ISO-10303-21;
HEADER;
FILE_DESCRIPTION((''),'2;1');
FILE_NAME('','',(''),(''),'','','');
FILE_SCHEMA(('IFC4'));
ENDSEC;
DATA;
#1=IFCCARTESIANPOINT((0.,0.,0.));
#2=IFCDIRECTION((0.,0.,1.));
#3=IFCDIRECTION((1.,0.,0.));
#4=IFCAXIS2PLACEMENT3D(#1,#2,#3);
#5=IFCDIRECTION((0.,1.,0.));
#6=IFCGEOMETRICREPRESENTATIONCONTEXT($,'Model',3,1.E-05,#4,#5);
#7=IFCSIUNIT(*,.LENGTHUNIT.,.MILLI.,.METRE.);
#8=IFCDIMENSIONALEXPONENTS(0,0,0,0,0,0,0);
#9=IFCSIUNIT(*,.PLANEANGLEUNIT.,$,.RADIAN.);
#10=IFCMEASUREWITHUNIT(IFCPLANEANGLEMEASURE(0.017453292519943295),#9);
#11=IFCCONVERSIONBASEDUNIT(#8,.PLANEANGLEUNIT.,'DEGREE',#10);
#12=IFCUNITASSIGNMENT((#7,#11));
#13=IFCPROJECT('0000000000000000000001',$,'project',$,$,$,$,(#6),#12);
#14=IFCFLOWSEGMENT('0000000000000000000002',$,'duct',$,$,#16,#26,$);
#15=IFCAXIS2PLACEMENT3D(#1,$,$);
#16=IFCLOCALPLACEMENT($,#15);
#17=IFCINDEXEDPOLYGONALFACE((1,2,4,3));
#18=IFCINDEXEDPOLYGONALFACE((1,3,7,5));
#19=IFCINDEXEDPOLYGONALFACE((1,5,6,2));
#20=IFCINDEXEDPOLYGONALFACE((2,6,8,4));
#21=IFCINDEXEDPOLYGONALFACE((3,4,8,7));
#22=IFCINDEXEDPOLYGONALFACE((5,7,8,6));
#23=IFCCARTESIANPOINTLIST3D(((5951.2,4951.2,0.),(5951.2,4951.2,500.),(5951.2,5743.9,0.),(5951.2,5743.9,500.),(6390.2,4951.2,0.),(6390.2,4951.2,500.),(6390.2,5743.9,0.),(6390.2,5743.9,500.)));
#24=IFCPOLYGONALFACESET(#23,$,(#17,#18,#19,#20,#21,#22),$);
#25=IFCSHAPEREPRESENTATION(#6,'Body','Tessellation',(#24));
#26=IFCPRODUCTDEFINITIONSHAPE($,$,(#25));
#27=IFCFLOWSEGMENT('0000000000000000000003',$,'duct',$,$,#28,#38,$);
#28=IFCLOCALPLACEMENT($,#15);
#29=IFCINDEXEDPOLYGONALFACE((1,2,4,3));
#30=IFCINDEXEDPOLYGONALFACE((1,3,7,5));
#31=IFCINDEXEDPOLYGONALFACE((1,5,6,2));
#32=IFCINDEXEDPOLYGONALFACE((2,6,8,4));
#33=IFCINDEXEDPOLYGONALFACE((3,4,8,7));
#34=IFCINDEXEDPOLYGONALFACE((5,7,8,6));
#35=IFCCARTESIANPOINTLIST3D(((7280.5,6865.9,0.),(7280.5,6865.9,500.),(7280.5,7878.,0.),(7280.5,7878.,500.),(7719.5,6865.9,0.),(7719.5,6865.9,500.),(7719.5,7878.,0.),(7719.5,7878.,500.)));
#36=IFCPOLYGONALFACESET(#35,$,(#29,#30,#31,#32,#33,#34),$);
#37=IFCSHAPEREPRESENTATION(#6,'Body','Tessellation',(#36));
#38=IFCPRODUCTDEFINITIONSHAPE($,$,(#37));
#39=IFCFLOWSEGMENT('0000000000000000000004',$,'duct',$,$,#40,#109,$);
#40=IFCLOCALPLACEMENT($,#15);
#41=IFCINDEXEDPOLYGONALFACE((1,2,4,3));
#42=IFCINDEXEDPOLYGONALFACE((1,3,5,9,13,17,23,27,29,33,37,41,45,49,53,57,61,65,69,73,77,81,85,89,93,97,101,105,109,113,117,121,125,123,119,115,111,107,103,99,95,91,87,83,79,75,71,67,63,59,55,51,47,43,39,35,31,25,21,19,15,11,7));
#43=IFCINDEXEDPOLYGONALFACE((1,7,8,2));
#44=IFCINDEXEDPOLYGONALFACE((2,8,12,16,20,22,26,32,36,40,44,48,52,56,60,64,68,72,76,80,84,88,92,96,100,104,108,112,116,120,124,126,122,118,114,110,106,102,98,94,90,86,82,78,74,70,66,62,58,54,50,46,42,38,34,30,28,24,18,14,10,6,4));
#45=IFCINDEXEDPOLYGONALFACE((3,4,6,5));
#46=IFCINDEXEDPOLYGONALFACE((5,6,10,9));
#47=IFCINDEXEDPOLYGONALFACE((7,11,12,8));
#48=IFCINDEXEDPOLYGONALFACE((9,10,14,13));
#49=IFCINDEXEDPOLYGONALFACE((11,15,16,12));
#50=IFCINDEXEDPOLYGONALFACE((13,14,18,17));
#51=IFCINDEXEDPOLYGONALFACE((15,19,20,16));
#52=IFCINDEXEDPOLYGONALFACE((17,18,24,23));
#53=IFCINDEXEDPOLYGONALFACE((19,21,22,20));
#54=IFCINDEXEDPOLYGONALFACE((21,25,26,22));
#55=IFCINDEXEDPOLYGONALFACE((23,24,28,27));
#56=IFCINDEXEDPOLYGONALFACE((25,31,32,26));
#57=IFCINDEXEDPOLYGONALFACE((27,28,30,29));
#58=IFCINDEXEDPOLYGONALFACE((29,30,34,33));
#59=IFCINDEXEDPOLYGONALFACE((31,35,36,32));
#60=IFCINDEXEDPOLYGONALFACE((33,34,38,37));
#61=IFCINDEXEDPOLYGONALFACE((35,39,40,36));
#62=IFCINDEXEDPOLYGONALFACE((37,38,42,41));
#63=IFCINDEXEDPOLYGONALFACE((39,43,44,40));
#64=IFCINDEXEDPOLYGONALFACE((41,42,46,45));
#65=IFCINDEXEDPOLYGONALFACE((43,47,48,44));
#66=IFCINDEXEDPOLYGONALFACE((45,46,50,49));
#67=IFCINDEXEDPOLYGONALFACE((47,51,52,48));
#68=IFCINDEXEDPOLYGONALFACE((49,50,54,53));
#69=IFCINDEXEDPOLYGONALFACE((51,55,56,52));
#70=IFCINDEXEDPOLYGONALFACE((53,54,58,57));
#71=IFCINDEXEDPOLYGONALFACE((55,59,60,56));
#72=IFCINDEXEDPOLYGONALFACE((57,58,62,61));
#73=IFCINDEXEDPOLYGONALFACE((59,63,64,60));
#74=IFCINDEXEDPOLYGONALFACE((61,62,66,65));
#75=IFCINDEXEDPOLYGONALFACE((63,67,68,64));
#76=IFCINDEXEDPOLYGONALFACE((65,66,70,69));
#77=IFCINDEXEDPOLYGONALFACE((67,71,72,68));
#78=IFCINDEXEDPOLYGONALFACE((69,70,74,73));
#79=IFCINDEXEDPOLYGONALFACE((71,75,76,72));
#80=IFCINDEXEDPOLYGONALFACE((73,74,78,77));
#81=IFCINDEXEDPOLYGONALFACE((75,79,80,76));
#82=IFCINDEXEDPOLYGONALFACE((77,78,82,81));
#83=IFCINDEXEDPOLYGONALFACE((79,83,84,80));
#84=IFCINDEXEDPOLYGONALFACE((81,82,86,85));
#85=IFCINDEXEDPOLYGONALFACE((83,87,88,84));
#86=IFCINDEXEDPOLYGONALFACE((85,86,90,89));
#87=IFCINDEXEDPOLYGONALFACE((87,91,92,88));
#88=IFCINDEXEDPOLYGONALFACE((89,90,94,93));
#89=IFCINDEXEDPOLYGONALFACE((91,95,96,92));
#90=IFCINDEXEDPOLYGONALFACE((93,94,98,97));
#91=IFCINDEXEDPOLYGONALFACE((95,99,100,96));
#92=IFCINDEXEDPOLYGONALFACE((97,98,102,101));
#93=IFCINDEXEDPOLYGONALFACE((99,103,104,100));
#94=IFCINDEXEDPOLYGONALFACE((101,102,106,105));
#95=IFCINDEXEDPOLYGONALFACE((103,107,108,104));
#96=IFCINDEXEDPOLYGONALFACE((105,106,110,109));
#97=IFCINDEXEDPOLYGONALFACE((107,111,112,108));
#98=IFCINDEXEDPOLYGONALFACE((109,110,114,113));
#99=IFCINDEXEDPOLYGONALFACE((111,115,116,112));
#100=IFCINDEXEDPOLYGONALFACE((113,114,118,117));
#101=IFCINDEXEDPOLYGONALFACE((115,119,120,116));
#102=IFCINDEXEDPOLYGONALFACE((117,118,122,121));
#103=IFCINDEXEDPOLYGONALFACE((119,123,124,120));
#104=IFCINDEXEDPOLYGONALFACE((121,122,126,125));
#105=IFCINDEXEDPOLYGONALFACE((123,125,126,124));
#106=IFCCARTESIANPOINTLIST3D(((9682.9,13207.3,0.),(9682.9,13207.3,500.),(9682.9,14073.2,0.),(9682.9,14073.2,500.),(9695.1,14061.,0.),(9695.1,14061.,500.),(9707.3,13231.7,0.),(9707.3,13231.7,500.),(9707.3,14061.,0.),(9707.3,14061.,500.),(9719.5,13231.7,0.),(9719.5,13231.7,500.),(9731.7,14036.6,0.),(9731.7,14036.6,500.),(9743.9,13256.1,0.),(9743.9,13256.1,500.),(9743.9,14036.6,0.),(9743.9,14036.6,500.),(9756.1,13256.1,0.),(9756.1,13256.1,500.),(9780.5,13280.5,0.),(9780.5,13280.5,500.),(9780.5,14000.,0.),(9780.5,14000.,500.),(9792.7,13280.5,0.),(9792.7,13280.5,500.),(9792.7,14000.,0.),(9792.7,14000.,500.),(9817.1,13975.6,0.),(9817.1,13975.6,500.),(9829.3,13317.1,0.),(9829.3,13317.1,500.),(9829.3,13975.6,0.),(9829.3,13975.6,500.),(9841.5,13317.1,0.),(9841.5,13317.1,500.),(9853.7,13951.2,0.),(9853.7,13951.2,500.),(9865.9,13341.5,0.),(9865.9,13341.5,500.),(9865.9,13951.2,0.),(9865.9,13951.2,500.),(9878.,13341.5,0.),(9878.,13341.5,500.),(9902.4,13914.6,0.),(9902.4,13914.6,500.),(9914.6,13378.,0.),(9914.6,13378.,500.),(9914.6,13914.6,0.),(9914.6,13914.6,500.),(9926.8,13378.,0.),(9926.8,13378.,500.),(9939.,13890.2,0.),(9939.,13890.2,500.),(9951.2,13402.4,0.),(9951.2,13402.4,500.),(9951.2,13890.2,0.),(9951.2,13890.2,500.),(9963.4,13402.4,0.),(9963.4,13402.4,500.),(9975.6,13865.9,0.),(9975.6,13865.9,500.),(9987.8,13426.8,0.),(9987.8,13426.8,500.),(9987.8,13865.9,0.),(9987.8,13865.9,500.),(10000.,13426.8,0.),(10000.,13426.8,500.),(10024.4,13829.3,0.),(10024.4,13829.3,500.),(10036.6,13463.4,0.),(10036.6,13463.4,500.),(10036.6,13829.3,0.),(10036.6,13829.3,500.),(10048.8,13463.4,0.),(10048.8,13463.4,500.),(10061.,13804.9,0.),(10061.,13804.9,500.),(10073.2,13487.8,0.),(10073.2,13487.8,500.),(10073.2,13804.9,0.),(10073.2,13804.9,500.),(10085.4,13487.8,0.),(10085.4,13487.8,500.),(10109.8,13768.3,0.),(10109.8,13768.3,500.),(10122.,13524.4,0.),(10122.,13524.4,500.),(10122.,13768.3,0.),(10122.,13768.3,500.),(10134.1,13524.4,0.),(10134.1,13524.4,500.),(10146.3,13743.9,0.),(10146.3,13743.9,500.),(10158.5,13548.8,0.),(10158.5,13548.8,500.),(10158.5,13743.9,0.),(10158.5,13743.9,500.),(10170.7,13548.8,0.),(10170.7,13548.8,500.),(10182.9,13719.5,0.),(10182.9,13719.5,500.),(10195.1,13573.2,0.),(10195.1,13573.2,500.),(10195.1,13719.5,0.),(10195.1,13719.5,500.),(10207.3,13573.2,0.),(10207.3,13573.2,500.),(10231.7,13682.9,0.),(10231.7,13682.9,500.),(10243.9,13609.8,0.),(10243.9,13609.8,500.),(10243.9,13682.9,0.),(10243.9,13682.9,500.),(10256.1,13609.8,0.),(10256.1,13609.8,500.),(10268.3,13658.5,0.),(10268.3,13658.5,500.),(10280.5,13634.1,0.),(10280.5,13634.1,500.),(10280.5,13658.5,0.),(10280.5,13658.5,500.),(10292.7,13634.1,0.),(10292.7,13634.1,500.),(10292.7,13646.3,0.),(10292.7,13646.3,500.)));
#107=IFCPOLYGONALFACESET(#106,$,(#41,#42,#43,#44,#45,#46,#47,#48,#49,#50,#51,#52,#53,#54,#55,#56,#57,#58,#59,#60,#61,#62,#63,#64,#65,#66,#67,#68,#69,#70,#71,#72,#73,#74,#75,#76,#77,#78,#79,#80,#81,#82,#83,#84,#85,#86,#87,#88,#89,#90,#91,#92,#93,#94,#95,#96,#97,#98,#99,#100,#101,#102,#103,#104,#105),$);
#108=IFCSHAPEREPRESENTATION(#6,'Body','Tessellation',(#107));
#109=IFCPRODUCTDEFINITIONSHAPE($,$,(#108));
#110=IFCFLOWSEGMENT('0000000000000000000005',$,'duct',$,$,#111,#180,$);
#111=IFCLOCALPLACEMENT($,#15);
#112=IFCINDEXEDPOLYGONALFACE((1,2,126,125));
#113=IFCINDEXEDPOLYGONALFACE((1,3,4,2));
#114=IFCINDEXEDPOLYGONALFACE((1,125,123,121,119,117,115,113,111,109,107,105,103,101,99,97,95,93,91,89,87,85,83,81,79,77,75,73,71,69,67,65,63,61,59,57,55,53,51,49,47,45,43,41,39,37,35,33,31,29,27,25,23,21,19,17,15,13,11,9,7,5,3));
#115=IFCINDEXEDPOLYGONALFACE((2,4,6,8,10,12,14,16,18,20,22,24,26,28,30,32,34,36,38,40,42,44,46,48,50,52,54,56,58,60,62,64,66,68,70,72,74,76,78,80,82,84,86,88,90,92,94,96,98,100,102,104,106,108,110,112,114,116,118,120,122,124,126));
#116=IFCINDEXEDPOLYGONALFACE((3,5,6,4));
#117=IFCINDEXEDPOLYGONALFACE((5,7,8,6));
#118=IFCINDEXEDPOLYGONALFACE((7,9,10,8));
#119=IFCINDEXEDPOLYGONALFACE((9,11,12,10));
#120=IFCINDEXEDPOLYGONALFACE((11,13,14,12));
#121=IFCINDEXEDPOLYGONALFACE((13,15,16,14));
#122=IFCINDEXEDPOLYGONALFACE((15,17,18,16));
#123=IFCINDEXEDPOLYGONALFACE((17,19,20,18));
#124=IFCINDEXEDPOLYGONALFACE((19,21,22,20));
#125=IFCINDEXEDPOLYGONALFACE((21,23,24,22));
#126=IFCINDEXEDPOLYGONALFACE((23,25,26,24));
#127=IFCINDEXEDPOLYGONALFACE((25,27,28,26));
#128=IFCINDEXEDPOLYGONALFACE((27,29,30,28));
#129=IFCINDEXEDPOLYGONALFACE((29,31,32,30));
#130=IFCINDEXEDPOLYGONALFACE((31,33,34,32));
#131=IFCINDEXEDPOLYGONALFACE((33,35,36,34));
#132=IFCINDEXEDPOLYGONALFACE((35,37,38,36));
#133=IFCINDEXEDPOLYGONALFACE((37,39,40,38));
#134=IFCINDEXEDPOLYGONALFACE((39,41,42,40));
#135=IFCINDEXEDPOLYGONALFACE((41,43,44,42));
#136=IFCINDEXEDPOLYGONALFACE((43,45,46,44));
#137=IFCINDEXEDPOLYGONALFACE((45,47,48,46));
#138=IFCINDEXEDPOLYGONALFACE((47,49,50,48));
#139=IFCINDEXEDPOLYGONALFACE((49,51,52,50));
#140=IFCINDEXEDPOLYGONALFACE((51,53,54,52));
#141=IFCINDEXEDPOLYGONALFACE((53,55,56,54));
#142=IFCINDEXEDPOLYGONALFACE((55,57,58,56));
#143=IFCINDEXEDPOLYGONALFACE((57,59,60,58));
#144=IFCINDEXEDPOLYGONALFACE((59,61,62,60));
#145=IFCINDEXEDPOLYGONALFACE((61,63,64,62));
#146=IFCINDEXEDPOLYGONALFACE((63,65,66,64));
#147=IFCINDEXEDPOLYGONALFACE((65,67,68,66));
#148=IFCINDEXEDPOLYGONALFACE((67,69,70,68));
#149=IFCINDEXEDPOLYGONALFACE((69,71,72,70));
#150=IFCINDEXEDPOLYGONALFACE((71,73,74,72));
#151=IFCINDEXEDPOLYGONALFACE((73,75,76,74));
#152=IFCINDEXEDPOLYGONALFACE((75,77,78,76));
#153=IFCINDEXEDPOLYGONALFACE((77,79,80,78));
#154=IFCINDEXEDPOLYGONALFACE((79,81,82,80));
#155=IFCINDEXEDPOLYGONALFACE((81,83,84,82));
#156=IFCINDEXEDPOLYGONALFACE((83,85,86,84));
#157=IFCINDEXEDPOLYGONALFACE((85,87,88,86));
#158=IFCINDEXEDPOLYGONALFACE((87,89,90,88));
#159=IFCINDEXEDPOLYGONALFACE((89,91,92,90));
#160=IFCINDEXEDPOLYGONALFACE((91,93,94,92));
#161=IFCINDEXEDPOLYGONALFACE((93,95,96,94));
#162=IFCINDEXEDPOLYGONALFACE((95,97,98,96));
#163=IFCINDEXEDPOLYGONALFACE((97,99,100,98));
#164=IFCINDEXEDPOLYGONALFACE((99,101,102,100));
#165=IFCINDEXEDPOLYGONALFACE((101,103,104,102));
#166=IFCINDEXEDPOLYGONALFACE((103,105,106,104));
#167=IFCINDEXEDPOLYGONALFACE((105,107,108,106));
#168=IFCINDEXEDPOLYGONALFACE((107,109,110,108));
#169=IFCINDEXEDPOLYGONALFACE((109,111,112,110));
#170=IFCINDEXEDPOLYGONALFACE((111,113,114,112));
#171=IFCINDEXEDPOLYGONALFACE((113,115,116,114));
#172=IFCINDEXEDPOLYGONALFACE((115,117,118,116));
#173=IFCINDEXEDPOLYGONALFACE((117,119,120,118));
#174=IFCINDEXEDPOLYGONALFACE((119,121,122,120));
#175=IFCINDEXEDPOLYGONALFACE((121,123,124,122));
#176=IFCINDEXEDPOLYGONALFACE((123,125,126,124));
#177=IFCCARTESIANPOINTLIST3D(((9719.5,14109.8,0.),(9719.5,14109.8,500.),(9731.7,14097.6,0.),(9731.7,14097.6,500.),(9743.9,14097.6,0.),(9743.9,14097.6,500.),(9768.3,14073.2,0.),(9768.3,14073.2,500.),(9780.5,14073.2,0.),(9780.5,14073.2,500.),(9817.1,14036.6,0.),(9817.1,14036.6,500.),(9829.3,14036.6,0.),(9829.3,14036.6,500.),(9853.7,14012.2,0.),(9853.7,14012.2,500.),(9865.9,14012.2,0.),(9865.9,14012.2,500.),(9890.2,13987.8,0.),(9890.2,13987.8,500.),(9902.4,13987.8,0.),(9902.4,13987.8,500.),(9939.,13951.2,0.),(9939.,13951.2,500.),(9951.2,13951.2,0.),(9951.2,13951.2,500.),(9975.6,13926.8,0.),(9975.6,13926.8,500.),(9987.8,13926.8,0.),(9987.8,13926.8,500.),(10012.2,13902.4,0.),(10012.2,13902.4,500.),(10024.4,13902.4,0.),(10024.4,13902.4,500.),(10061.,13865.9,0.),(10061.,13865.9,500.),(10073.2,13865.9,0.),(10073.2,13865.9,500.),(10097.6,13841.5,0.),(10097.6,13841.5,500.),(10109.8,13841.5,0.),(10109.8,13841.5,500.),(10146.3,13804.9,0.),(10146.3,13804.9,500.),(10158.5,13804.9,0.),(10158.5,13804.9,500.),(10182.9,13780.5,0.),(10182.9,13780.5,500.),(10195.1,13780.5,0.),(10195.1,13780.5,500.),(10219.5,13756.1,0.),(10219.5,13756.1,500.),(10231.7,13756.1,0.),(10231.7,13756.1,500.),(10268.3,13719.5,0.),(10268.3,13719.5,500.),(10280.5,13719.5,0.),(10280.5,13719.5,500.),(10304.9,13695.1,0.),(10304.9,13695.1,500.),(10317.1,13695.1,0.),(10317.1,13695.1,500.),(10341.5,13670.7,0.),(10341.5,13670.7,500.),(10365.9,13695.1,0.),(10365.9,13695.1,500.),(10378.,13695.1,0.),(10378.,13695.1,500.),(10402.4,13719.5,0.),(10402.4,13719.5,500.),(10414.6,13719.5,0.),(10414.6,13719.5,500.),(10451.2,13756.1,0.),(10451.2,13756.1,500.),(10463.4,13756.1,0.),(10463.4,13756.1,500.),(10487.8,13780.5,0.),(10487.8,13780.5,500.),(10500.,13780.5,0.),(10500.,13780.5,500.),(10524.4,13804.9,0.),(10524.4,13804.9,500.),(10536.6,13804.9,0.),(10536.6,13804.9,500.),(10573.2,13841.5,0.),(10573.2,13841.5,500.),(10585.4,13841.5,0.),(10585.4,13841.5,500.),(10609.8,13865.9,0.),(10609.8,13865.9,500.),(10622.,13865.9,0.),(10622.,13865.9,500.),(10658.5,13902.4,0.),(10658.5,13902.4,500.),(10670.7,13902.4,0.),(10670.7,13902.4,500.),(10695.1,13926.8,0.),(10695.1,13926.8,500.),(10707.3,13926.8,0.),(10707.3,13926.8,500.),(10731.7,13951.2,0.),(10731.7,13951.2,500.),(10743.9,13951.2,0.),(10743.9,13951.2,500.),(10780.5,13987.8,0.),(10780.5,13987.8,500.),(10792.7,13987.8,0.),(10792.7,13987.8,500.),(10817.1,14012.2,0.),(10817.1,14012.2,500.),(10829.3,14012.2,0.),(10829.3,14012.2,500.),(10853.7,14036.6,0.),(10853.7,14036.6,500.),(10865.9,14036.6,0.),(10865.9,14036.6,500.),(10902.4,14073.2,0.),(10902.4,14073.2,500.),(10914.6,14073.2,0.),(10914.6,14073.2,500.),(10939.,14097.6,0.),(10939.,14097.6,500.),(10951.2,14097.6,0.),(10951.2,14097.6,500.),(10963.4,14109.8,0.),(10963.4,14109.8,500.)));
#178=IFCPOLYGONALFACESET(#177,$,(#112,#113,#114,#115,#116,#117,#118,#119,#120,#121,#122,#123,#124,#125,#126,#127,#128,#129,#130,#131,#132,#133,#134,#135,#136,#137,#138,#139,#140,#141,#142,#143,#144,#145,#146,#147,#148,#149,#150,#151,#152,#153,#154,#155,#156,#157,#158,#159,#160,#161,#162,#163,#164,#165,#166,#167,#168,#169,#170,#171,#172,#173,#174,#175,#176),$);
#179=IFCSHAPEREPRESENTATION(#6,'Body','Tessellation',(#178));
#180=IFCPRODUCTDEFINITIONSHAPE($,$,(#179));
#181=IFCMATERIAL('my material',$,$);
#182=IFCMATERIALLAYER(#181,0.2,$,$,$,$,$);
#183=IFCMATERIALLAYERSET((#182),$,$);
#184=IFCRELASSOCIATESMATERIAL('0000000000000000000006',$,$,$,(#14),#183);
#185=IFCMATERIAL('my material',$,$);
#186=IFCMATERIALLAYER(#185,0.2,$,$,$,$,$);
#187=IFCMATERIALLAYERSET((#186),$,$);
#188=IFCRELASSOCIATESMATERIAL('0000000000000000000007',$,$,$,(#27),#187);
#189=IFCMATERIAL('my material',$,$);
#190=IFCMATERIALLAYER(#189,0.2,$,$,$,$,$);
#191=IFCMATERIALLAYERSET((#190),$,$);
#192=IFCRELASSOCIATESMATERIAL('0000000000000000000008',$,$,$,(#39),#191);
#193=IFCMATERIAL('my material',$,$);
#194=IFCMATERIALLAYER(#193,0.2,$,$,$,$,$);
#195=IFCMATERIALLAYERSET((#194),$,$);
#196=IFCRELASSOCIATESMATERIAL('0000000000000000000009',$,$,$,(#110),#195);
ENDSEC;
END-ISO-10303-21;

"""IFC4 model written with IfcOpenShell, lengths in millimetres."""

from ifc_helpers import new_model, entity, si_unit, converted_unit, direction, origin_with_axes, place, context, project, polyline, outline, extrude, material, layer, layer_set, layer_usage, element, save


model = new_model("IFC4")

# Units and contexts
model_context = context("Model", 3, precision=1e-05, world=origin_with_axes(), true_north=direction((0.0, 1.0, 0.0)))
ifc_project = project(units=[si_unit("LENGTHUNIT", "METRE", prefix="MILLI"), converted_unit("PLANEANGLEUNIT", "DEGREE", entity("IfcPlaneAngleMeasure", 0.017453292519943295), si_unit("PLANEANGLEUNIT", "RADIAN"), dimensions=[0, 0, 0, 0, 0, 0, 0])], contexts=[model_context])

# Flow segments
ifc_material_1 = material(Name="my material")
ifc_layer_1 = layer(ifc_material_1, 0.2)
ifc_layer_set_1 = layer_set([ifc_layer_1])
ifc_layer_usage_1 = layer_usage(ifc_layer_set_1, "AXIS2", "POSITIVE", -0.1)
flow_segment_1_placement = place(None, origin_with_axes())
element("IfcFlowSegment", 1, at=flow_segment_1_placement, material=ifc_layer_usage_1, Name="duct", context=model_context, shape_type="SweptSolid", body=[
    extrude(outline(polyline([(5951.2, 4951.2), (6390.2, 4951.2), (6390.2, 5743.9), (5951.2, 5743.9), (5951.2, 4951.2)])), origin_with_axes(), (0.0, 0.0, 1.0), 500.0),
])
ifc_material_2 = material(Name="my material")
ifc_layer_2 = layer(ifc_material_2, 0.2)
ifc_layer_set_2 = layer_set([ifc_layer_2])
ifc_layer_usage_2 = layer_usage(ifc_layer_set_2, "AXIS2", "POSITIVE", -0.1)
flow_segment_2_placement = place(None, origin_with_axes())
element("IfcFlowSegment", 2, at=flow_segment_2_placement, material=ifc_layer_usage_2, Name="duct", context=model_context, shape_type="SweptSolid", body=[
    extrude(outline(polyline([(7280.5, 6865.9), (7719.5, 6865.9), (7719.5, 7878.0), (7280.5, 7878.0), (7280.5, 6865.9)])), origin_with_axes(), (0.0, 0.0, 1.0), 500.0),
])
ifc_material_3 = material(Name="my material")
ifc_layer_3 = layer(ifc_material_3, 0.2)
ifc_layer_set_3 = layer_set([ifc_layer_3])
ifc_layer_usage_3 = layer_usage(ifc_layer_set_3, "AXIS2", "POSITIVE", -0.1)
flow_segment_3_placement = place(None, origin_with_axes())
element("IfcFlowSegment", 3, at=flow_segment_3_placement, material=ifc_layer_usage_3, Name="duct", context=model_context, shape_type="SweptSolid", body=[
    extrude(outline(polyline([(9682.9, 13207.3), (9707.3, 13231.7), (9719.5, 13231.7), (9743.9, 13256.1), (9756.1, 13256.1), (9780.5, 13280.5), (9792.7, 13280.5), (9829.3, 13317.1), (9841.5, 13317.1), (9865.9, 13341.5), (9878.0, 13341.5), (9914.6, 13378.0), (9926.8, 13378.0), (9951.2, 13402.4), (9963.4, 13402.4), (9987.8, 13426.8), (10000.0, 13426.8), (10036.6, 13463.4), (10048.8, 13463.4), (10073.2, 13487.8), (10085.4, 13487.8), (10122.0, 13524.4), (10134.1, 13524.4), (10158.5, 13548.8), (10170.7, 13548.8), (10195.1, 13573.2), (10207.3, 13573.2), (10243.9, 13609.8), (10256.1, 13609.8), (10280.5, 13634.1), (10292.7, 13634.1), (10292.7, 13646.3), (10280.5, 13658.5), (10268.3, 13658.5), (10243.9, 13682.9), (10231.7, 13682.9), (10195.1, 13719.5), (10182.9, 13719.5), (10158.5, 13743.9), (10146.3, 13743.9), (10122.0, 13768.3), (10109.8, 13768.3), (10073.2, 13804.9), (10061.0, 13804.9), (10036.6, 13829.3), (10024.4, 13829.3), (9987.8, 13865.9), (9975.6, 13865.9), (9951.2, 13890.2), (9939.0, 13890.2), (9914.6, 13914.6), (9902.4, 13914.6), (9865.9, 13951.2), (9853.7, 13951.2), (9829.3, 13975.6), (9817.1, 13975.6), (9792.7, 14000.0), (9780.5, 14000.0), (9743.9, 14036.6), (9731.7, 14036.6), (9707.3, 14061.0), (9695.1, 14061.0), (9682.9, 14073.2), (9682.9, 13207.3)])), origin_with_axes(), (0.0, 0.0, 1.0), 500.0),
])
ifc_material_4 = material(Name="my material")
ifc_layer_4 = layer(ifc_material_4, 0.2)
ifc_layer_set_4 = layer_set([ifc_layer_4])
ifc_layer_usage_4 = layer_usage(ifc_layer_set_4, "AXIS2", "POSITIVE", -0.1)
flow_segment_4_placement = place(None, origin_with_axes())
element("IfcFlowSegment", 4, at=flow_segment_4_placement, material=ifc_layer_usage_4, Name="duct", context=model_context, shape_type="SweptSolid", body=[
    extrude(outline(polyline([(9719.5, 14109.8), (9731.7, 14097.6), (9743.9, 14097.6), (9768.3, 14073.2), (9780.5, 14073.2), (9817.1, 14036.6), (9829.3, 14036.6), (9853.7, 14012.2), (9865.9, 14012.2), (9890.2, 13987.8), (9902.4, 13987.8), (9939.0, 13951.2), (9951.2, 13951.2), (9975.6, 13926.8), (9987.8, 13926.8), (10012.2, 13902.4), (10024.4, 13902.4), (10061.0, 13865.9), (10073.2, 13865.9), (10097.6, 13841.5), (10109.8, 13841.5), (10146.3, 13804.9), (10158.5, 13804.9), (10182.9, 13780.5), (10195.1, 13780.5), (10219.5, 13756.1), (10231.7, 13756.1), (10268.3, 13719.5), (10280.5, 13719.5), (10304.9, 13695.1), (10317.1, 13695.1), (10341.5, 13670.7), (10365.9, 13695.1), (10378.0, 13695.1), (10402.4, 13719.5), (10414.6, 13719.5), (10451.2, 13756.1), (10463.4, 13756.1), (10487.8, 13780.5), (10500.0, 13780.5), (10524.4, 13804.9), (10536.6, 13804.9), (10573.2, 13841.5), (10585.4, 13841.5), (10609.8, 13865.9), (10622.0, 13865.9), (10658.5, 13902.4), (10670.7, 13902.4), (10695.1, 13926.8), (10707.3, 13926.8), (10731.7, 13951.2), (10743.9, 13951.2), (10780.5, 13987.8), (10792.7, 13987.8), (10817.1, 14012.2), (10829.3, 14012.2), (10853.7, 14036.6), (10865.9, 14036.6), (10902.4, 14073.2), (10914.6, 14073.2), (10939.0, 14097.6), (10951.2, 14097.6), (10963.4, 14109.8), (9719.5, 14109.8)])), origin_with_axes(), (0.0, 0.0, 1.0), 500.0),
])

save(model, "model.ifc")
